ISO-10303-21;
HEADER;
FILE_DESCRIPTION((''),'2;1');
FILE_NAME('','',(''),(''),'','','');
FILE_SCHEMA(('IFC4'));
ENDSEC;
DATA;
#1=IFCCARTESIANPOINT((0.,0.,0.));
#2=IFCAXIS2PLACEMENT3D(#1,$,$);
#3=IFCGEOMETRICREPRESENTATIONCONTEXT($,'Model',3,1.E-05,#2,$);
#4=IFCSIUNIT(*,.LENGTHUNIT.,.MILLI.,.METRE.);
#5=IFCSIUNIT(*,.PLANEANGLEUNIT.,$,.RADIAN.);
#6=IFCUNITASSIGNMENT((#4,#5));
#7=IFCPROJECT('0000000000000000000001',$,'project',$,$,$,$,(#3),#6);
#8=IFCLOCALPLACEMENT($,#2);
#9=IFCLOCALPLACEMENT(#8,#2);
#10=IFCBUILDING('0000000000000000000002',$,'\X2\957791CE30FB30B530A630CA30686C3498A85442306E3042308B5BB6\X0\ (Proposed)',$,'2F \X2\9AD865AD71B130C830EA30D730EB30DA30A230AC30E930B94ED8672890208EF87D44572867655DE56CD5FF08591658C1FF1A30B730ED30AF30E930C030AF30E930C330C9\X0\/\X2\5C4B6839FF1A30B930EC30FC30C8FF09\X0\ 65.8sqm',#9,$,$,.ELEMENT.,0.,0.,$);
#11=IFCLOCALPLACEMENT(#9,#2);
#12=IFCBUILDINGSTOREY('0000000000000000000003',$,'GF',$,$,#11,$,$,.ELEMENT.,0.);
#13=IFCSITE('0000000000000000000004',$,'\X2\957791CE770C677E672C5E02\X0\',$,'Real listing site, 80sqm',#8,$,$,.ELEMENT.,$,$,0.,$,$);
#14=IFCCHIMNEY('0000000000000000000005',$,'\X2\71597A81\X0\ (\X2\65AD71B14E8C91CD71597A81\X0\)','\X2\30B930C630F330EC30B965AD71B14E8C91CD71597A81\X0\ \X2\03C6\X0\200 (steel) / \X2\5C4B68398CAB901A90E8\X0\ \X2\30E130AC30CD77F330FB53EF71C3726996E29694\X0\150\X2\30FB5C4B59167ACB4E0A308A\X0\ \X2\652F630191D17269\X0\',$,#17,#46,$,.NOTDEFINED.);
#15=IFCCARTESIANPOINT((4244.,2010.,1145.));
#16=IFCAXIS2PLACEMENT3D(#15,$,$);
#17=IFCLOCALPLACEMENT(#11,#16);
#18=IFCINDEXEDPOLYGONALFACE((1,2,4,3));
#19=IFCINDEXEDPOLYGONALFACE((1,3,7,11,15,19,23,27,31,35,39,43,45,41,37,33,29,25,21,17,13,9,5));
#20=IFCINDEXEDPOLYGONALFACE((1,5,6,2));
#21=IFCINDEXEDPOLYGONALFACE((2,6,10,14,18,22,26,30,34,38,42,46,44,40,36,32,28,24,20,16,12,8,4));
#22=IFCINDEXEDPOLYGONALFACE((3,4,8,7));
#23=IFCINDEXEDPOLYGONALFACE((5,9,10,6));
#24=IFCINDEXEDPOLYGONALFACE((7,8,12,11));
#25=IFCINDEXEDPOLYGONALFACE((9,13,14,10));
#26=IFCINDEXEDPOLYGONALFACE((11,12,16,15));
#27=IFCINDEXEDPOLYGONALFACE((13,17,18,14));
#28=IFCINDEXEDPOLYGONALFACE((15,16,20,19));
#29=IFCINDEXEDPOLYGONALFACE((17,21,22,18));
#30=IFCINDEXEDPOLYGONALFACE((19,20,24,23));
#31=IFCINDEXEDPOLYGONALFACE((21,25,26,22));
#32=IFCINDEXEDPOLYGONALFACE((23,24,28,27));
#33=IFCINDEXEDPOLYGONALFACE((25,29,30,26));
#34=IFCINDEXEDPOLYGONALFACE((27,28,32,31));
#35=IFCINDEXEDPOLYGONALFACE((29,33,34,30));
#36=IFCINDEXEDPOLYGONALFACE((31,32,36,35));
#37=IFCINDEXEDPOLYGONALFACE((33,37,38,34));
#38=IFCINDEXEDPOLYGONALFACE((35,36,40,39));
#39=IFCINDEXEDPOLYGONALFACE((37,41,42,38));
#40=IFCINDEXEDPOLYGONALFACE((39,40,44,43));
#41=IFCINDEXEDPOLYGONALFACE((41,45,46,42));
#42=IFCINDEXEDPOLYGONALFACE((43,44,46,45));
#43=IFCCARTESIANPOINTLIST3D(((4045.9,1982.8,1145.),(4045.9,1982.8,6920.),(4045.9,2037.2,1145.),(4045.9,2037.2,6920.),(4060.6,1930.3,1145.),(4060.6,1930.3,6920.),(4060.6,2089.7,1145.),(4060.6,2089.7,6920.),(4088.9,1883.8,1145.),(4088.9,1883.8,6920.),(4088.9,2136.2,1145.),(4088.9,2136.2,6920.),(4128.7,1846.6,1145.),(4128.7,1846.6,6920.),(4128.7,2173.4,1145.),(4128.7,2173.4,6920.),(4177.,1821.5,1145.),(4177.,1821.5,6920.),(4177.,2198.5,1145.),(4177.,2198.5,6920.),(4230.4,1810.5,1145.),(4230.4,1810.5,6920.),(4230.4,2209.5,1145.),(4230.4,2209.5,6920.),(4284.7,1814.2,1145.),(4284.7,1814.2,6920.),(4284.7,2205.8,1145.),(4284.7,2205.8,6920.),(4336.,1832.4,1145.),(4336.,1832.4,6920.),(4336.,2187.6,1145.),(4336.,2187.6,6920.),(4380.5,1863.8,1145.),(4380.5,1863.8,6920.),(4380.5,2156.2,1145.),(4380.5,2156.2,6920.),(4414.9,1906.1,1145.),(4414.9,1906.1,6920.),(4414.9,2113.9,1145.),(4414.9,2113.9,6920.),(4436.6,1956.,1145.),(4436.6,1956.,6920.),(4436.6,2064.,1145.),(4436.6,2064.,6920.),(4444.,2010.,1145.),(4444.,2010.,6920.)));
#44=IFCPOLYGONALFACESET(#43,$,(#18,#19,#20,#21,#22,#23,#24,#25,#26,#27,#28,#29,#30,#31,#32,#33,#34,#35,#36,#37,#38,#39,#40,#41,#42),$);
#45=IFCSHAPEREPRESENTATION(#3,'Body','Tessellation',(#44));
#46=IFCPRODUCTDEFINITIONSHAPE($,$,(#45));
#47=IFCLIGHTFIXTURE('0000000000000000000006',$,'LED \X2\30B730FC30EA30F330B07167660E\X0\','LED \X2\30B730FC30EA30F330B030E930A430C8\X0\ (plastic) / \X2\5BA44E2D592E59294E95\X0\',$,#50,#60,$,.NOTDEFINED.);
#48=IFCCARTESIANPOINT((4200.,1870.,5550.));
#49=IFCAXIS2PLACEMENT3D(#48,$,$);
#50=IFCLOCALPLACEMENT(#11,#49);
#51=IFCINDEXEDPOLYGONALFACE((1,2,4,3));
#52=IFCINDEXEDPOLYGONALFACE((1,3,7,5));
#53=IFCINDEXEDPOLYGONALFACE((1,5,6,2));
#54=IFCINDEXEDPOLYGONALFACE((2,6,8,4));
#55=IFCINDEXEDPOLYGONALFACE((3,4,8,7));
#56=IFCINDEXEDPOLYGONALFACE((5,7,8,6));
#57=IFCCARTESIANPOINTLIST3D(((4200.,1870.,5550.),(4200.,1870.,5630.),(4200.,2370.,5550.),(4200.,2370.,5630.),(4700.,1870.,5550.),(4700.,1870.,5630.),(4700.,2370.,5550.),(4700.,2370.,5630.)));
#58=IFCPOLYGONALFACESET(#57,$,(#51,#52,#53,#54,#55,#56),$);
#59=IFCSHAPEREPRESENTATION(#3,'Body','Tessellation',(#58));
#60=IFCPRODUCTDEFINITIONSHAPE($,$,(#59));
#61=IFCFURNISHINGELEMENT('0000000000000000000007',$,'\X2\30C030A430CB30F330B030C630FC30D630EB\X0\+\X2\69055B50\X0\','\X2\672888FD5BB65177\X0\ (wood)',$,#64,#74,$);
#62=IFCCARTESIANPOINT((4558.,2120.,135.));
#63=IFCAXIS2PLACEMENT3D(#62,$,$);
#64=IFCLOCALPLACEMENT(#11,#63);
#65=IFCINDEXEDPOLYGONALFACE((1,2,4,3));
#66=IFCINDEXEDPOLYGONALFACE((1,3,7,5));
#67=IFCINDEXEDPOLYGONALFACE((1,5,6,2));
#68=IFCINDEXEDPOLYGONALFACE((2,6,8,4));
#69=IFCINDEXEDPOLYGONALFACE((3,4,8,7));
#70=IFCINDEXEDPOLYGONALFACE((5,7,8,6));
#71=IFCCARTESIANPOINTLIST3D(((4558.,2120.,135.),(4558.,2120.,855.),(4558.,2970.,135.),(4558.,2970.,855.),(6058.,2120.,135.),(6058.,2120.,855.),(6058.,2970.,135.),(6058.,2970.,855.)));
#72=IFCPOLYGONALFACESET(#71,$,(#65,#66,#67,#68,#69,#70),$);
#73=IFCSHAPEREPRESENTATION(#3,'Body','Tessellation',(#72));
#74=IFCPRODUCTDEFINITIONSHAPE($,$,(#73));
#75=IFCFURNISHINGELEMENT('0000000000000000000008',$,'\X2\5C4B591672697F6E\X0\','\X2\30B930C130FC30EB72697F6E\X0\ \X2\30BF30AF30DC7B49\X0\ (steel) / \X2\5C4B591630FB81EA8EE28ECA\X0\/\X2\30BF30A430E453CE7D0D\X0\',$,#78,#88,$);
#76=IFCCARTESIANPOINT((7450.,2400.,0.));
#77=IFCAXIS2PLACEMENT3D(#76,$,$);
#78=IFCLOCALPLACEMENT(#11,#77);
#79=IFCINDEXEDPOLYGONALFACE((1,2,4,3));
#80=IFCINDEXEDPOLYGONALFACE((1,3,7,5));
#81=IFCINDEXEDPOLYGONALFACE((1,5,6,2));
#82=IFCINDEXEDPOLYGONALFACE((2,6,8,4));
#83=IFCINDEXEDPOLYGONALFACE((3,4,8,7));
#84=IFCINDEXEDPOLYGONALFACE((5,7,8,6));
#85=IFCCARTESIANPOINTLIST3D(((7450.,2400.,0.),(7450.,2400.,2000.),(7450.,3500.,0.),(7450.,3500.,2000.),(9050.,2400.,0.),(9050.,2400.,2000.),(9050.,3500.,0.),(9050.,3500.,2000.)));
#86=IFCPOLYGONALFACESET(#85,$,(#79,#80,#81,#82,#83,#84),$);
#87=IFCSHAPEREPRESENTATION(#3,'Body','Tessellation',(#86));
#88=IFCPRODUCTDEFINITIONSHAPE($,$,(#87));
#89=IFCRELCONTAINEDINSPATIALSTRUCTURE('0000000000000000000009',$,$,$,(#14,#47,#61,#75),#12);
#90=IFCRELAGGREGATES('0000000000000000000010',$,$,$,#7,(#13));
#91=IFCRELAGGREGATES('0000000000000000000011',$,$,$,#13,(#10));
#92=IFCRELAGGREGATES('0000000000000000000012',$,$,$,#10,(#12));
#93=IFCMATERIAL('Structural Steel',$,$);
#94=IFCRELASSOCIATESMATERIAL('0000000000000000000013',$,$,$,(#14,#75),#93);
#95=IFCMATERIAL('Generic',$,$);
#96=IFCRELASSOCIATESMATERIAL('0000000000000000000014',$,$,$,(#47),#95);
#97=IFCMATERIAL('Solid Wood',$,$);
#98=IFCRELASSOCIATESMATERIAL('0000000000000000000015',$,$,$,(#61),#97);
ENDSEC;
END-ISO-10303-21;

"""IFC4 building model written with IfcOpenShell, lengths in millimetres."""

from ifc_helpers import new_model, si_unit, frame, frame_2d, origin, origin_2d, place, context, project, spatial, rectangle, circle, extrude, material, element, save


model = new_model("IFC4")

# Units and contexts
model_context = context("Model", 3, precision=1e-05, world=origin())
ifc_project = project(units=[si_unit("LENGTHUNIT", "METRE", prefix="MILLI"), si_unit("PLANEANGLEUNIT", "RADIAN")], contexts=[model_context])

# Site, building, storey
site_placement = place(None, origin())
site = spatial("IfcSite", under=ifc_project, at=site_placement, Name="長野県松本市", ObjectType="Real listing site, 80sqm", CompositionType="ELEMENT", RefElevation=0.0)
building_placement = place(site_placement, origin())
building = spatial("IfcBuilding", under=site, at=building_placement, Name="長野・サウナと水風呂のある家 (Proposed)", ObjectType="2F 高断熱トリプルペアガラス付木造軸組在来工法（外壁：シロクラダクラッド/屋根：スレート） 65.8sqm", CompositionType="ELEMENT", ElevationOfRefHeight=0.0, ElevationOfTerrain=0.0)
storey_placement = place(building_placement, origin())
storey = spatial("IfcBuildingStorey", under=building, at=storey_placement, Name="GF", CompositionType="ELEMENT", Elevation=0.0)

# Shared definitions
ifc_material_1 = material(Name="Solid Wood")

# Shared definitions
ifc_material_2 = material(Name="Structural Steel")

# Chimney
chimney_placement = place(storey_placement, frame((4244.0, 2010.0, 1145.0)))
element("IfcChimney", 1, at=chimney_placement, inside=storey, material=ifc_material_2, Name="煙突 (断熱二重煙突)", Description="ステンレス断熱二重煙突 φ200 (steel) / 屋根貫通部 メガネ石・可燃物離隔150・屋外立上り 支持金物", PredefinedType="NOTDEFINED", context=model_context, shape_type="SweptSolid", body=[
    extrude(circle(Radius=200.0, at=origin_2d()), frame((4244.0, 2010.0, 1145.0)), (0.0, 0.0, 1.0), 5775.0),
])

# Light fixture
ifc_material_3 = material(Name="Generic")
light_fixture_placement = place(storey_placement, frame((4200.0, 1870.0, 5550.0)))
element("IfcLightFixture", 2, at=light_fixture_placement, inside=storey, material=ifc_material_3, Name="LED シーリング照明", Description="LED シーリングライト (plastic) / 室中央天井", PredefinedType="NOTDEFINED", context=model_context, shape_type="SweptSolid", body=[
    extrude(rectangle(XDim=500.0, YDim=500.0, at=frame_2d((250.0, 250.0))), frame((4200.0, 1870.0, 5550.0)), (0.0, 0.0, 1.0), 80.0),
])

# Furnishing elements
furnishing_1_placement = place(storey_placement, frame((4558.0, 2120.0, 135.0)))
element("IfcFurnishingElement", 3, at=furnishing_1_placement, inside=storey, material=ifc_material_1, Name="ダイニングテーブル+椅子", Description="木製家具 (wood)", context=model_context, shape_type="SweptSolid", body=[
    extrude(rectangle(XDim=1500.0, YDim=850.0, at=frame_2d((750.0, 425.0))), frame((4558.0, 2120.0, 135.0)), (0.0, 0.0, 1.0), 720.0),
])
furnishing_2_placement = place(storey_placement, frame((7450.0, 2400.0, 0.0)))
element("IfcFurnishingElement", 4, at=furnishing_2_placement, inside=storey, material=ifc_material_2, Name="屋外物置", Description="スチール物置 タクボ等 (steel) / 屋外・自転車/タイヤ収納", context=model_context, shape_type="SweptSolid", body=[
    extrude(rectangle(XDim=1600.0, YDim=1100.0, at=frame_2d((800.0, 550.0))), frame((7450.0, 2400.0, 0.0)), (0.0, 0.0, 1.0), 2000.0),
])

save(model, "model.ifc")
